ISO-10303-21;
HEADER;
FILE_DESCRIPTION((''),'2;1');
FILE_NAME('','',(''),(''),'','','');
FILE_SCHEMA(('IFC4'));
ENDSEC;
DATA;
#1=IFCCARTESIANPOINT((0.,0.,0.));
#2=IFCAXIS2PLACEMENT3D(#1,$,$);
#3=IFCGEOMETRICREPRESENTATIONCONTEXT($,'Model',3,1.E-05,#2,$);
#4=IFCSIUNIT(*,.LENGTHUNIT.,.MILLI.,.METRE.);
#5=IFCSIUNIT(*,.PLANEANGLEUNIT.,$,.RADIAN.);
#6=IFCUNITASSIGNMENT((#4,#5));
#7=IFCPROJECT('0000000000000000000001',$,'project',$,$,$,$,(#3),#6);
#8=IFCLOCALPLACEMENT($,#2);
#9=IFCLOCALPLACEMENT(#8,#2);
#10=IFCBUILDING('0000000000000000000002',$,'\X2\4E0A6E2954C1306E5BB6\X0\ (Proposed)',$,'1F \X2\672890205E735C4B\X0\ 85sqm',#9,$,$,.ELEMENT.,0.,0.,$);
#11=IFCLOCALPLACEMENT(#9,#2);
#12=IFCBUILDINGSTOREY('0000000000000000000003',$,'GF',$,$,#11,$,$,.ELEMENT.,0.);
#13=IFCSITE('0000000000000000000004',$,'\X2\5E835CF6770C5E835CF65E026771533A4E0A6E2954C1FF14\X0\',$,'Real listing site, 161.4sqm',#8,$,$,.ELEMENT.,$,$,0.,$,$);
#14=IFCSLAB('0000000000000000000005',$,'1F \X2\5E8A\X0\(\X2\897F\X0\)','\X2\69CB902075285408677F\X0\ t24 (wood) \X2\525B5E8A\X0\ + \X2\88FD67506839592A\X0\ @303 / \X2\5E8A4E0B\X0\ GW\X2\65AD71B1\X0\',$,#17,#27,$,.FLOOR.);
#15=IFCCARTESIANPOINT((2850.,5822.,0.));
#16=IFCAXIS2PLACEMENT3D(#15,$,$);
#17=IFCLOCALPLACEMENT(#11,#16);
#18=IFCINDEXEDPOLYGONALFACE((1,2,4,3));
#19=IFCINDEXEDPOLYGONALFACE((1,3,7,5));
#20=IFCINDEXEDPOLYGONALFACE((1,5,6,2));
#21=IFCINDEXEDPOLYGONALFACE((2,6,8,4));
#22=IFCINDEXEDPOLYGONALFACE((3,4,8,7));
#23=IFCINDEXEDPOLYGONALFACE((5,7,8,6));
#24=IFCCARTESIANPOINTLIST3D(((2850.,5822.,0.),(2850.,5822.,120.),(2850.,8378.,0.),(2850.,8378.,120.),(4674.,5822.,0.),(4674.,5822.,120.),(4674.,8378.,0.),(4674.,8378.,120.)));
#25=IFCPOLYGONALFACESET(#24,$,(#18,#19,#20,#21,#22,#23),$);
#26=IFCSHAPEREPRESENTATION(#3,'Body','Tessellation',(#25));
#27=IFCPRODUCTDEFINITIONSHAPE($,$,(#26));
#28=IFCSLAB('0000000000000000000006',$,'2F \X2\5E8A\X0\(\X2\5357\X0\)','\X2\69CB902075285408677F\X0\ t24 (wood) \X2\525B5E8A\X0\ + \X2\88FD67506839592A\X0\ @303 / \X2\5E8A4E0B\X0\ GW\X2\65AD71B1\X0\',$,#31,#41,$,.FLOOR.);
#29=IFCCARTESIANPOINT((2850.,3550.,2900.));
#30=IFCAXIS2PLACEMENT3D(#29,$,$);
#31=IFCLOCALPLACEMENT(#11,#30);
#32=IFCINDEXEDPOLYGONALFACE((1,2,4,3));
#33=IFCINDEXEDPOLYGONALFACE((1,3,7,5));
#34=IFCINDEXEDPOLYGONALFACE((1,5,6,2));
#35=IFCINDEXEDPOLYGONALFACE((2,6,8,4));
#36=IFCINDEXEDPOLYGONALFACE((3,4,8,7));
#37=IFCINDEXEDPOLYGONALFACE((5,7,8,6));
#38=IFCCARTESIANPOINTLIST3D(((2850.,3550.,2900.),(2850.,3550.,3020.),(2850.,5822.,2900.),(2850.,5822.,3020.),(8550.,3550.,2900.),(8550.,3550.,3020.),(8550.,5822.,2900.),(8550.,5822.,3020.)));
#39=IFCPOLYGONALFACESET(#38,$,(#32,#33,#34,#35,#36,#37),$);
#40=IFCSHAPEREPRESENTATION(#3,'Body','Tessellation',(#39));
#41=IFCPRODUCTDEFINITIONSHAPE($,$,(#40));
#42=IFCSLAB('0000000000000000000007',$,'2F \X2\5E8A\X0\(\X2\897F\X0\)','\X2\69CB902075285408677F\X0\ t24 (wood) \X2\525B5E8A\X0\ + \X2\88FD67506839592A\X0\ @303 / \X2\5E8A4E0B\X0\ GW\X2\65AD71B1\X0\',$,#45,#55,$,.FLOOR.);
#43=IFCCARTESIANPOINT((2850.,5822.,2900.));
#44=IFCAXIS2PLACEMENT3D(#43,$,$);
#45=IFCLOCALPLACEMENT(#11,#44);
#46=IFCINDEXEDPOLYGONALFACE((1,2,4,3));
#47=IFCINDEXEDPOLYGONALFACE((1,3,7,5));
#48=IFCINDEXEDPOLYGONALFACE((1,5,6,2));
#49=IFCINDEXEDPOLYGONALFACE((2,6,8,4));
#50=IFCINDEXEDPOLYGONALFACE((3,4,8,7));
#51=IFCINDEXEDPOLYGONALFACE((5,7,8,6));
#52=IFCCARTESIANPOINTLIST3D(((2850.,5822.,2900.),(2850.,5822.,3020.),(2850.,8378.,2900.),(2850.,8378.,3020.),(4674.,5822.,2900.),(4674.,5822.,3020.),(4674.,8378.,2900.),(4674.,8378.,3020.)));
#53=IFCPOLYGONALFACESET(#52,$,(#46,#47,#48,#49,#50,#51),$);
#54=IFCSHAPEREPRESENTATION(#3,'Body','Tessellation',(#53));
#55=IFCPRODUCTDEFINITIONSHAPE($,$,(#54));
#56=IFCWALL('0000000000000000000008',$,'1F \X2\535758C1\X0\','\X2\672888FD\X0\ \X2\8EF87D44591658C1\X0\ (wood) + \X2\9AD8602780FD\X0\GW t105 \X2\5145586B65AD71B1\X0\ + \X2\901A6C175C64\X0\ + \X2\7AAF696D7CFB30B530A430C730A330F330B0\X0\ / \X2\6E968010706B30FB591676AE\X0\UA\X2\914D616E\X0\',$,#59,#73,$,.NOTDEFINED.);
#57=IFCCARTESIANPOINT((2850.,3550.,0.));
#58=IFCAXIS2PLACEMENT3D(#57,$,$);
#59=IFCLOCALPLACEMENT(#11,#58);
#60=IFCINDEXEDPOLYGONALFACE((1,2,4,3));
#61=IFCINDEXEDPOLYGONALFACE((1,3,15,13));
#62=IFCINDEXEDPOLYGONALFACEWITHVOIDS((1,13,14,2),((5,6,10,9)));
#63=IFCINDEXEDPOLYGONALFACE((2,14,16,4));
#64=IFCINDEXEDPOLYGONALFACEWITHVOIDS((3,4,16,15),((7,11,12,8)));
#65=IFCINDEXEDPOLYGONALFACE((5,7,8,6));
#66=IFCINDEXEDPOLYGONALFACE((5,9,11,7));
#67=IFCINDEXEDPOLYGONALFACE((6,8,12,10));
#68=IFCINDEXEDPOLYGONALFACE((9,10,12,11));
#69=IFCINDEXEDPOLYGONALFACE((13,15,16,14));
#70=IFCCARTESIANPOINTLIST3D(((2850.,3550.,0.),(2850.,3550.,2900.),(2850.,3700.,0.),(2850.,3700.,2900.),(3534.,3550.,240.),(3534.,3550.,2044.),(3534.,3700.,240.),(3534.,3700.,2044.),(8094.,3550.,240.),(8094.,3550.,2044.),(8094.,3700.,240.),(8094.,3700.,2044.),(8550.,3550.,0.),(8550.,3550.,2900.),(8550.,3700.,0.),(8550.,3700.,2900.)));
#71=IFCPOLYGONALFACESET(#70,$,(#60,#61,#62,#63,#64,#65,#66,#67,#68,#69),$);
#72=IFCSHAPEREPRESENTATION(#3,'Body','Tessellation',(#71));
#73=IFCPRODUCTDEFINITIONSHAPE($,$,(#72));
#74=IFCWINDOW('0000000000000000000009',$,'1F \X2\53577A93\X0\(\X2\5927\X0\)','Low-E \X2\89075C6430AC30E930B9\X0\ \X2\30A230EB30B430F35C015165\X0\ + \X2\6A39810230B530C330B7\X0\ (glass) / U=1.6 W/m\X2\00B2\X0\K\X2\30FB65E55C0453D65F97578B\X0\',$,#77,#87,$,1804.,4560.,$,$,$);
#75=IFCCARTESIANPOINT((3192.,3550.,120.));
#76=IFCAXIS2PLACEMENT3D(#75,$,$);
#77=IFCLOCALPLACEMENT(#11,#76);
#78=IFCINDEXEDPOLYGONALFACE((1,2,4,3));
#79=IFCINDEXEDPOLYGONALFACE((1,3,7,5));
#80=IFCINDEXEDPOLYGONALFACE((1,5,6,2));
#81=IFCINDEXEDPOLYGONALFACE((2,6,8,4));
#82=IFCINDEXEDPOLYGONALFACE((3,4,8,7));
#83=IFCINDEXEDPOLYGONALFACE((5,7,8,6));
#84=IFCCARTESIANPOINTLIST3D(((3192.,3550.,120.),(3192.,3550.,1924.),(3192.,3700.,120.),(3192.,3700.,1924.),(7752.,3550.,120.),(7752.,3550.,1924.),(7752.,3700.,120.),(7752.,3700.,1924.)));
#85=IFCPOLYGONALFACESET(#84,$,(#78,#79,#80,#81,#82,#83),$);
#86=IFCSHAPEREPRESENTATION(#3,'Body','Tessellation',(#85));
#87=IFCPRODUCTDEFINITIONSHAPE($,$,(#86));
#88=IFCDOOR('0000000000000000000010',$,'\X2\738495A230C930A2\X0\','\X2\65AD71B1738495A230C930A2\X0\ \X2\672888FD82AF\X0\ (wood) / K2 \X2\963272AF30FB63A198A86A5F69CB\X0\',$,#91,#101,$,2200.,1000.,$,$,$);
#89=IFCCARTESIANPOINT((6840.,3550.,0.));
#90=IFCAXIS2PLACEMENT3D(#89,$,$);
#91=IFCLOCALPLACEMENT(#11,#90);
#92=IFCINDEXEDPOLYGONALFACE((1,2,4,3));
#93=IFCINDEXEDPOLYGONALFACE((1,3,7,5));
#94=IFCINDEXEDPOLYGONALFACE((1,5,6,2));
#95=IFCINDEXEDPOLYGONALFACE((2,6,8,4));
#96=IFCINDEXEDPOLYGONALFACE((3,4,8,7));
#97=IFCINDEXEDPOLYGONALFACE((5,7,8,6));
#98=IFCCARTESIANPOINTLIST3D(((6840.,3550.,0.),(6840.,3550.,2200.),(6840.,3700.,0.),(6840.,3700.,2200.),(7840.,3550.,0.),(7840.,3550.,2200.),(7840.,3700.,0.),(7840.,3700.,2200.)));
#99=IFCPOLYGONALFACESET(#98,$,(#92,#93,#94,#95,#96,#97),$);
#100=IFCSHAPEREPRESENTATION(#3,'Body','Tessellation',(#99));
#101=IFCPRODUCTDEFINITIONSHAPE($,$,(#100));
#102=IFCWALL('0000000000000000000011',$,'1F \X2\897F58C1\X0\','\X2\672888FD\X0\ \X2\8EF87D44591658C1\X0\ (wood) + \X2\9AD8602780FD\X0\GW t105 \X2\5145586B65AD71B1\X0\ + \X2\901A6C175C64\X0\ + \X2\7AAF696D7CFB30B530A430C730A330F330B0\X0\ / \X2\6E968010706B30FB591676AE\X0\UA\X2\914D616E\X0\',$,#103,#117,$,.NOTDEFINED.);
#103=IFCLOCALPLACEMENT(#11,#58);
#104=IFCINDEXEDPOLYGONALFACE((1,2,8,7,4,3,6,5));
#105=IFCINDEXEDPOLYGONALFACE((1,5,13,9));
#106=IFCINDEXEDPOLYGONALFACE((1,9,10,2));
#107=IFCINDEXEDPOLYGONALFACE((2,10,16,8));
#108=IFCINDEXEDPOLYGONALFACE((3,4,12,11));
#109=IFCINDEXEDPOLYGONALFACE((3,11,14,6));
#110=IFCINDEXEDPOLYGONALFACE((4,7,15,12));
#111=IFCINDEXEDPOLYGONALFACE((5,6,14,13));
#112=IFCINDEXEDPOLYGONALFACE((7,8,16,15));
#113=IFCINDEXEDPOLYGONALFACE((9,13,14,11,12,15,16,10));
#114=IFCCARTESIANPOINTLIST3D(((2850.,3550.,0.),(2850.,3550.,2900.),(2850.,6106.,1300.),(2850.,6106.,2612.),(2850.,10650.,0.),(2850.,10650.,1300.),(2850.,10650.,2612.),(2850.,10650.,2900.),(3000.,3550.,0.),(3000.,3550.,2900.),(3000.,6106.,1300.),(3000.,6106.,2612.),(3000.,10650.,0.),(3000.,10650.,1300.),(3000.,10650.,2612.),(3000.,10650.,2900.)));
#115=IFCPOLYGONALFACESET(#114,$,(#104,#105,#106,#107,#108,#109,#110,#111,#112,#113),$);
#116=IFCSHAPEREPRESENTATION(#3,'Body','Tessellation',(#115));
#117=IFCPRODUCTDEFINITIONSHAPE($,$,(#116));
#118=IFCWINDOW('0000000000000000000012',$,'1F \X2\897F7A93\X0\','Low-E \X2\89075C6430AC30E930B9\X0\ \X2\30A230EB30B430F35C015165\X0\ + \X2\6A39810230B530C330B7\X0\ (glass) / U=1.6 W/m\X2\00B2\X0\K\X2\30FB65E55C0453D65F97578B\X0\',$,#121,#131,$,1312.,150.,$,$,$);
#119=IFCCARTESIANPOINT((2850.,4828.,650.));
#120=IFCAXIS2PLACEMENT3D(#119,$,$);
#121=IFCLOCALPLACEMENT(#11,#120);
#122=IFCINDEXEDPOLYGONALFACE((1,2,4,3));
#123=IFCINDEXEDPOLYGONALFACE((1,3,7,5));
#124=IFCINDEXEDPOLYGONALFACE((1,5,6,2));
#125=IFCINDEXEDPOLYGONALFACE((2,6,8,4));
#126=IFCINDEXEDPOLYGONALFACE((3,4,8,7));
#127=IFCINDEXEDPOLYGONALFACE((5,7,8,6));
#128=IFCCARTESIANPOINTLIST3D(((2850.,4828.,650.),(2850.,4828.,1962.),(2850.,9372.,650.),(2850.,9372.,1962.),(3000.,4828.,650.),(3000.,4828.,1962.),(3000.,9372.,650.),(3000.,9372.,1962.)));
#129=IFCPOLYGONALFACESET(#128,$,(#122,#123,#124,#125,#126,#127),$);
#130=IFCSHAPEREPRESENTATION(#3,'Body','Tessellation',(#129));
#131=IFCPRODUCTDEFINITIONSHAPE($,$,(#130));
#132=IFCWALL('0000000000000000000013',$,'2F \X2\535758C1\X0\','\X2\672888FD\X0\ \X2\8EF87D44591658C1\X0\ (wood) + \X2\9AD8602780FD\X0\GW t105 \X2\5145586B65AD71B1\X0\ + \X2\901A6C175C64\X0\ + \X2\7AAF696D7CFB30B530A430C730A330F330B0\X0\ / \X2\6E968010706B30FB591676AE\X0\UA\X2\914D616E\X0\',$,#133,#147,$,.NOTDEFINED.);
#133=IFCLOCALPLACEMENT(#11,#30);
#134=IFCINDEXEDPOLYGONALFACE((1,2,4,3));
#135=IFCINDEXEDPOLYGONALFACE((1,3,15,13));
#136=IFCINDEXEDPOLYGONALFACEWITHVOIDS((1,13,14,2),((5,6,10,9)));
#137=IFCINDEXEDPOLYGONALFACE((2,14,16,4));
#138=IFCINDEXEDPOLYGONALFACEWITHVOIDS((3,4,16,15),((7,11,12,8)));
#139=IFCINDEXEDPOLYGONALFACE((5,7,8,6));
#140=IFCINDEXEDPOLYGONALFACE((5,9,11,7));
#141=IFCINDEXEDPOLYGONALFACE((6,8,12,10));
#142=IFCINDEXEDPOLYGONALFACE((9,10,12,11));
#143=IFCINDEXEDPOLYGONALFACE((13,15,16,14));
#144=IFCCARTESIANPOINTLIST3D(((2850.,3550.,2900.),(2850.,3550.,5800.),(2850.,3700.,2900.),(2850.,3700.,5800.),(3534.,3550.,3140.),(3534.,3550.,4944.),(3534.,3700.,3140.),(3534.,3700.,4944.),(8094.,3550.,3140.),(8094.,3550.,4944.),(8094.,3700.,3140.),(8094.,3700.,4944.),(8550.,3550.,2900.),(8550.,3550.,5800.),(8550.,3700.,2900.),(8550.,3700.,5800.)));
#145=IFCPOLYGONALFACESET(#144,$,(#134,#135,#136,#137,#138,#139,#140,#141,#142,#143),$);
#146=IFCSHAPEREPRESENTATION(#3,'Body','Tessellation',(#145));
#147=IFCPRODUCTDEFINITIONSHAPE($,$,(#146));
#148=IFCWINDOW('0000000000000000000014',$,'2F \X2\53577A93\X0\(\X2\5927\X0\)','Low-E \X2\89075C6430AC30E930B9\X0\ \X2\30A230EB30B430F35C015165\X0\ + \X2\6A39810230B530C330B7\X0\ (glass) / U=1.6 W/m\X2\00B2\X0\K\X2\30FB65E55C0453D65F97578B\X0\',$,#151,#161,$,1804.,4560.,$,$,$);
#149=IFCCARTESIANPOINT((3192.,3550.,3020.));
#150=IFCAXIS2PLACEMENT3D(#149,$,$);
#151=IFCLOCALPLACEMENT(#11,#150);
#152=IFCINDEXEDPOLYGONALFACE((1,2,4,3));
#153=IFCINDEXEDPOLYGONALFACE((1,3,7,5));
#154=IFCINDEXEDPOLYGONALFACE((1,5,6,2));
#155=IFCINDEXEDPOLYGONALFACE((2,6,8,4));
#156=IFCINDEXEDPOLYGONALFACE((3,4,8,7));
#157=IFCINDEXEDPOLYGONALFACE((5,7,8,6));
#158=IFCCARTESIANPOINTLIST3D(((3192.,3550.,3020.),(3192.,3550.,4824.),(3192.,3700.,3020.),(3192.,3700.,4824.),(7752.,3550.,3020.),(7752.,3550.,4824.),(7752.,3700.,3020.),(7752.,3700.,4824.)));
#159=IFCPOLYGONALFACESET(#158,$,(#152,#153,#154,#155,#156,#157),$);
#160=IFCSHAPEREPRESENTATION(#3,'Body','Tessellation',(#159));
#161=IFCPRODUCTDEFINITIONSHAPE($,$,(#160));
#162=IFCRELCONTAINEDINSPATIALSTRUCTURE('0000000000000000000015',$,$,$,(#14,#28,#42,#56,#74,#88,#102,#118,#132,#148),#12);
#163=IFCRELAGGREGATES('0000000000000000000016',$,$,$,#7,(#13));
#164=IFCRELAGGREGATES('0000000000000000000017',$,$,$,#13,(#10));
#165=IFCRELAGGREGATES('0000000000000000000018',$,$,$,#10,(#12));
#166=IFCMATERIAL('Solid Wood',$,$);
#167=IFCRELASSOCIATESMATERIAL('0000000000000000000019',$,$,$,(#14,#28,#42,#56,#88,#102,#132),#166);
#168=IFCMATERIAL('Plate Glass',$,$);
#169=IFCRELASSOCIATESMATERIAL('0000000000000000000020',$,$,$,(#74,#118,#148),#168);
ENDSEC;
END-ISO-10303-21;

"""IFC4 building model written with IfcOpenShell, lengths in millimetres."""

from ifc_helpers import new_model, si_unit, frame, frame_2d, origin, place, context, project, spatial, rectangle, extrude, material, element, fill, save


model = new_model("IFC4")

# Units and contexts
model_context = context("Model", 3, precision=1e-05, world=origin())
ifc_project = project(units=[si_unit("LENGTHUNIT", "METRE", prefix="MILLI"), si_unit("PLANEANGLEUNIT", "RADIAN")], contexts=[model_context])

# Site, building, storey
site_placement = place(None, origin())
site = spatial("IfcSite", under=ifc_project, at=site_placement, Name="広島県広島市東区上温品４", ObjectType="Real listing site, 161.4sqm", CompositionType="ELEMENT", RefElevation=0.0)
building_placement = place(site_placement, origin())
building = spatial("IfcBuilding", under=site, at=building_placement, Name="上温品の家 (Proposed)", ObjectType="1F 木造平屋 85sqm", CompositionType="ELEMENT", ElevationOfRefHeight=0.0, ElevationOfTerrain=0.0)
storey_placement = place(building_placement, origin())
storey = spatial("IfcBuildingStorey", under=building, at=storey_placement, Name="GF", CompositionType="ELEMENT", Elevation=0.0)

# Slabs
ifc_material_1 = material(Name="Solid Wood")
slab_1_placement = place(storey_placement, frame((2850.0, 5822.0, 0.0)))
element("IfcSlab", 1, at=slab_1_placement, inside=storey, material=ifc_material_1, Name="1F 床(西)", Description="構造用合板 t24 (wood) 剛床 + 製材根太 @303 / 床下 GW断熱", PredefinedType="FLOOR", context=model_context, shape_type="SweptSolid", body=[
    extrude(rectangle(XDim=1824.0, YDim=2556.0, at=frame_2d((912.0, 1278.0))), frame((2850.0, 5822.0, 0.0)), (0.0, 0.0, 1.0), 120.0),
])
slab_2_placement = place(storey_placement, frame((2850.0, 3550.0, 2900.0)))
element("IfcSlab", 2, at=slab_2_placement, inside=storey, material=ifc_material_1, Name="2F 床(南)", Description="構造用合板 t24 (wood) 剛床 + 製材根太 @303 / 床下 GW断熱", PredefinedType="FLOOR", context=model_context, shape_type="SweptSolid", body=[
    extrude(rectangle(XDim=5700.0, YDim=2272.0, at=frame_2d((2850.0, 1136.0))), frame((2850.0, 3550.0, 2900.0)), (0.0, 0.0, 1.0), 120.0),
])
slab_3_placement = place(storey_placement, frame((2850.0, 5822.0, 2900.0)))
element("IfcSlab", 3, at=slab_3_placement, inside=storey, material=ifc_material_1, Name="2F 床(西)", Description="構造用合板 t24 (wood) 剛床 + 製材根太 @303 / 床下 GW断熱", PredefinedType="FLOOR", context=model_context, shape_type="SweptSolid", body=[
    extrude(rectangle(XDim=1824.0, YDim=2556.0, at=frame_2d((912.0, 1278.0))), frame((2850.0, 5822.0, 2900.0)), (0.0, 0.0, 1.0), 120.0),
])

# Wall, openings, window, door
wall_1_placement = place(storey_placement, frame((2850.0, 3550.0, 0.0)))
wall_1 = element("IfcWall", 4, at=wall_1_placement, inside=storey, material=ifc_material_1, Name="1F 南壁", Description="木製 軸組外壁 (wood) + 高性能GW t105 充填断熱 + 通気層 + 窯業系サイディング / 準耐火・外皮UA配慮", PredefinedType="NOTDEFINED", context=model_context, shape_type="SweptSolid", body=[
    extrude(rectangle(XDim=5700.0, YDim=150.0, at=frame_2d((2850.0, 75.0))), frame((2850.0, 3550.0, 0.0)), (0.0, 0.0, 1.0), 2900.0),
])
opening_1_placement = place(storey_placement, frame((3192.0, 3550.0, 120.0)))
opening_1 = element("IfcOpeningElement", 5, at=opening_1_placement, cuts=wall_1, PredefinedType="NOTDEFINED", context=model_context, shape_type="SweptSolid", body=[
    extrude(rectangle(XDim=4560.0, YDim=150.0, at=frame_2d((2280.0, 75.0))), frame((3192.0, 3550.0, 120.0)), (0.0, 0.0, 1.0), 1804.0),
])
opening_2_placement = place(storey_placement, frame((6840.0, 3550.0, 0.0)))
opening_2 = element("IfcOpeningElement", 6, at=opening_2_placement, cuts=wall_1, PredefinedType="NOTDEFINED", context=model_context, shape_type="SweptSolid", body=[
    extrude(rectangle(XDim=1000.0, YDim=150.0, at=frame_2d((500.0, 75.0))), frame((6840.0, 3550.0, 0.0)), (0.0, 0.0, 1.0), 2200.0),
])
ifc_material_2 = material(Name="Plate Glass")
window_1_placement = place(storey_placement, frame((3192.0, 3550.0, 120.0)))
window_1 = element("IfcWindow", 7, at=window_1_placement, inside=storey, material=ifc_material_2, Name="1F 南窓(大)", Description="Low-E 複層ガラス アルゴン封入 + 樹脂サッシ (glass) / U=1.6 W/m²K・日射取得型", OverallHeight=1804.0, OverallWidth=4560.0, context=model_context, shape_type="SweptSolid", body=[
    extrude(rectangle(XDim=4560.0, YDim=150.0, at=frame_2d((2280.0, 75.0))), frame((3192.0, 3550.0, 120.0)), (0.0, 0.0, 1.0), 1804.0),
])
fill(opening_1, window_1)
door_placement = place(storey_placement, frame((6840.0, 3550.0, 0.0)))
door = element("IfcDoor", 8, at=door_placement, inside=storey, material=ifc_material_1, Name="玄関ドア", Description="断熱玄関ドア 木製芯 (wood) / K2 防犯・採風機構", OverallHeight=2200.0, OverallWidth=1000.0, context=model_context, shape_type="SweptSolid", body=[
    extrude(rectangle(XDim=1000.0, YDim=150.0, at=frame_2d((500.0, 75.0))), frame((6840.0, 3550.0, 0.0)), (0.0, 0.0, 1.0), 2200.0),
])
fill(opening_2, door)

# Walls, openings, windows
wall_2_placement = place(storey_placement, frame((2850.0, 3550.0, 0.0)))
wall_2 = element("IfcWall", 9, at=wall_2_placement, inside=storey, material=ifc_material_1, Name="1F 西壁", Description="木製 軸組外壁 (wood) + 高性能GW t105 充填断熱 + 通気層 + 窯業系サイディング / 準耐火・外皮UA配慮", PredefinedType="NOTDEFINED", context=model_context, shape_type="SweptSolid", body=[
    extrude(rectangle(XDim=150.0, YDim=7100.0, at=frame_2d((75.0, 3550.0))), frame((2850.0, 3550.0, 0.0)), (0.0, 0.0, 1.0), 2900.0),
])
opening_3_placement = place(storey_placement, frame((2850.0, 4828.0, 650.0)))
opening_3 = element("IfcOpeningElement", 10, at=opening_3_placement, cuts=wall_2, PredefinedType="NOTDEFINED", context=model_context, shape_type="SweptSolid", body=[
    extrude(rectangle(XDim=150.0, YDim=4544.0, at=frame_2d((75.0, 2272.0))), frame((2850.0, 4828.0, 650.0)), (0.0, 0.0, 1.0), 1312.0),
])
window_2_placement = place(storey_placement, frame((2850.0, 4828.0, 650.0)))
window_2 = element("IfcWindow", 11, at=window_2_placement, inside=storey, material=ifc_material_2, Name="1F 西窓", Description="Low-E 複層ガラス アルゴン封入 + 樹脂サッシ (glass) / U=1.6 W/m²K・日射取得型", OverallHeight=1312.0, OverallWidth=150.0, context=model_context, shape_type="SweptSolid", body=[
    extrude(rectangle(XDim=150.0, YDim=4544.0, at=frame_2d((75.0, 2272.0))), frame((2850.0, 4828.0, 650.0)), (0.0, 0.0, 1.0), 1312.0),
])
fill(opening_3, window_2)
wall_3_placement = place(storey_placement, frame((2850.0, 3550.0, 2900.0)))
wall_3 = element("IfcWall", 12, at=wall_3_placement, inside=storey, material=ifc_material_1, Name="2F 南壁", Description="木製 軸組外壁 (wood) + 高性能GW t105 充填断熱 + 通気層 + 窯業系サイディング / 準耐火・外皮UA配慮", PredefinedType="NOTDEFINED", context=model_context, shape_type="SweptSolid", body=[
    extrude(rectangle(XDim=5700.0, YDim=150.0, at=frame_2d((2850.0, 75.0))), frame((2850.0, 3550.0, 2900.0)), (0.0, 0.0, 1.0), 2900.0),
])
opening_4_placement = place(storey_placement, frame((3192.0, 3550.0, 3020.0)))
opening_4 = element("IfcOpeningElement", 13, at=opening_4_placement, cuts=wall_3, PredefinedType="NOTDEFINED", context=model_context, shape_type="SweptSolid", body=[
    extrude(rectangle(XDim=4560.0, YDim=150.0, at=frame_2d((2280.0, 75.0))), frame((3192.0, 3550.0, 3020.0)), (0.0, 0.0, 1.0), 1804.0),
])
window_3_placement = place(storey_placement, frame((3192.0, 3550.0, 3020.0)))
window_3 = element("IfcWindow", 14, at=window_3_placement, inside=storey, material=ifc_material_2, Name="2F 南窓(大)", Description="Low-E 複層ガラス アルゴン封入 + 樹脂サッシ (glass) / U=1.6 W/m²K・日射取得型", OverallHeight=1804.0, OverallWidth=4560.0, context=model_context, shape_type="SweptSolid", body=[
    extrude(rectangle(XDim=4560.0, YDim=150.0, at=frame_2d((2280.0, 75.0))), frame((3192.0, 3550.0, 3020.0)), (0.0, 0.0, 1.0), 1804.0),
])
fill(opening_4, window_3)

save(model, "model.ifc")
